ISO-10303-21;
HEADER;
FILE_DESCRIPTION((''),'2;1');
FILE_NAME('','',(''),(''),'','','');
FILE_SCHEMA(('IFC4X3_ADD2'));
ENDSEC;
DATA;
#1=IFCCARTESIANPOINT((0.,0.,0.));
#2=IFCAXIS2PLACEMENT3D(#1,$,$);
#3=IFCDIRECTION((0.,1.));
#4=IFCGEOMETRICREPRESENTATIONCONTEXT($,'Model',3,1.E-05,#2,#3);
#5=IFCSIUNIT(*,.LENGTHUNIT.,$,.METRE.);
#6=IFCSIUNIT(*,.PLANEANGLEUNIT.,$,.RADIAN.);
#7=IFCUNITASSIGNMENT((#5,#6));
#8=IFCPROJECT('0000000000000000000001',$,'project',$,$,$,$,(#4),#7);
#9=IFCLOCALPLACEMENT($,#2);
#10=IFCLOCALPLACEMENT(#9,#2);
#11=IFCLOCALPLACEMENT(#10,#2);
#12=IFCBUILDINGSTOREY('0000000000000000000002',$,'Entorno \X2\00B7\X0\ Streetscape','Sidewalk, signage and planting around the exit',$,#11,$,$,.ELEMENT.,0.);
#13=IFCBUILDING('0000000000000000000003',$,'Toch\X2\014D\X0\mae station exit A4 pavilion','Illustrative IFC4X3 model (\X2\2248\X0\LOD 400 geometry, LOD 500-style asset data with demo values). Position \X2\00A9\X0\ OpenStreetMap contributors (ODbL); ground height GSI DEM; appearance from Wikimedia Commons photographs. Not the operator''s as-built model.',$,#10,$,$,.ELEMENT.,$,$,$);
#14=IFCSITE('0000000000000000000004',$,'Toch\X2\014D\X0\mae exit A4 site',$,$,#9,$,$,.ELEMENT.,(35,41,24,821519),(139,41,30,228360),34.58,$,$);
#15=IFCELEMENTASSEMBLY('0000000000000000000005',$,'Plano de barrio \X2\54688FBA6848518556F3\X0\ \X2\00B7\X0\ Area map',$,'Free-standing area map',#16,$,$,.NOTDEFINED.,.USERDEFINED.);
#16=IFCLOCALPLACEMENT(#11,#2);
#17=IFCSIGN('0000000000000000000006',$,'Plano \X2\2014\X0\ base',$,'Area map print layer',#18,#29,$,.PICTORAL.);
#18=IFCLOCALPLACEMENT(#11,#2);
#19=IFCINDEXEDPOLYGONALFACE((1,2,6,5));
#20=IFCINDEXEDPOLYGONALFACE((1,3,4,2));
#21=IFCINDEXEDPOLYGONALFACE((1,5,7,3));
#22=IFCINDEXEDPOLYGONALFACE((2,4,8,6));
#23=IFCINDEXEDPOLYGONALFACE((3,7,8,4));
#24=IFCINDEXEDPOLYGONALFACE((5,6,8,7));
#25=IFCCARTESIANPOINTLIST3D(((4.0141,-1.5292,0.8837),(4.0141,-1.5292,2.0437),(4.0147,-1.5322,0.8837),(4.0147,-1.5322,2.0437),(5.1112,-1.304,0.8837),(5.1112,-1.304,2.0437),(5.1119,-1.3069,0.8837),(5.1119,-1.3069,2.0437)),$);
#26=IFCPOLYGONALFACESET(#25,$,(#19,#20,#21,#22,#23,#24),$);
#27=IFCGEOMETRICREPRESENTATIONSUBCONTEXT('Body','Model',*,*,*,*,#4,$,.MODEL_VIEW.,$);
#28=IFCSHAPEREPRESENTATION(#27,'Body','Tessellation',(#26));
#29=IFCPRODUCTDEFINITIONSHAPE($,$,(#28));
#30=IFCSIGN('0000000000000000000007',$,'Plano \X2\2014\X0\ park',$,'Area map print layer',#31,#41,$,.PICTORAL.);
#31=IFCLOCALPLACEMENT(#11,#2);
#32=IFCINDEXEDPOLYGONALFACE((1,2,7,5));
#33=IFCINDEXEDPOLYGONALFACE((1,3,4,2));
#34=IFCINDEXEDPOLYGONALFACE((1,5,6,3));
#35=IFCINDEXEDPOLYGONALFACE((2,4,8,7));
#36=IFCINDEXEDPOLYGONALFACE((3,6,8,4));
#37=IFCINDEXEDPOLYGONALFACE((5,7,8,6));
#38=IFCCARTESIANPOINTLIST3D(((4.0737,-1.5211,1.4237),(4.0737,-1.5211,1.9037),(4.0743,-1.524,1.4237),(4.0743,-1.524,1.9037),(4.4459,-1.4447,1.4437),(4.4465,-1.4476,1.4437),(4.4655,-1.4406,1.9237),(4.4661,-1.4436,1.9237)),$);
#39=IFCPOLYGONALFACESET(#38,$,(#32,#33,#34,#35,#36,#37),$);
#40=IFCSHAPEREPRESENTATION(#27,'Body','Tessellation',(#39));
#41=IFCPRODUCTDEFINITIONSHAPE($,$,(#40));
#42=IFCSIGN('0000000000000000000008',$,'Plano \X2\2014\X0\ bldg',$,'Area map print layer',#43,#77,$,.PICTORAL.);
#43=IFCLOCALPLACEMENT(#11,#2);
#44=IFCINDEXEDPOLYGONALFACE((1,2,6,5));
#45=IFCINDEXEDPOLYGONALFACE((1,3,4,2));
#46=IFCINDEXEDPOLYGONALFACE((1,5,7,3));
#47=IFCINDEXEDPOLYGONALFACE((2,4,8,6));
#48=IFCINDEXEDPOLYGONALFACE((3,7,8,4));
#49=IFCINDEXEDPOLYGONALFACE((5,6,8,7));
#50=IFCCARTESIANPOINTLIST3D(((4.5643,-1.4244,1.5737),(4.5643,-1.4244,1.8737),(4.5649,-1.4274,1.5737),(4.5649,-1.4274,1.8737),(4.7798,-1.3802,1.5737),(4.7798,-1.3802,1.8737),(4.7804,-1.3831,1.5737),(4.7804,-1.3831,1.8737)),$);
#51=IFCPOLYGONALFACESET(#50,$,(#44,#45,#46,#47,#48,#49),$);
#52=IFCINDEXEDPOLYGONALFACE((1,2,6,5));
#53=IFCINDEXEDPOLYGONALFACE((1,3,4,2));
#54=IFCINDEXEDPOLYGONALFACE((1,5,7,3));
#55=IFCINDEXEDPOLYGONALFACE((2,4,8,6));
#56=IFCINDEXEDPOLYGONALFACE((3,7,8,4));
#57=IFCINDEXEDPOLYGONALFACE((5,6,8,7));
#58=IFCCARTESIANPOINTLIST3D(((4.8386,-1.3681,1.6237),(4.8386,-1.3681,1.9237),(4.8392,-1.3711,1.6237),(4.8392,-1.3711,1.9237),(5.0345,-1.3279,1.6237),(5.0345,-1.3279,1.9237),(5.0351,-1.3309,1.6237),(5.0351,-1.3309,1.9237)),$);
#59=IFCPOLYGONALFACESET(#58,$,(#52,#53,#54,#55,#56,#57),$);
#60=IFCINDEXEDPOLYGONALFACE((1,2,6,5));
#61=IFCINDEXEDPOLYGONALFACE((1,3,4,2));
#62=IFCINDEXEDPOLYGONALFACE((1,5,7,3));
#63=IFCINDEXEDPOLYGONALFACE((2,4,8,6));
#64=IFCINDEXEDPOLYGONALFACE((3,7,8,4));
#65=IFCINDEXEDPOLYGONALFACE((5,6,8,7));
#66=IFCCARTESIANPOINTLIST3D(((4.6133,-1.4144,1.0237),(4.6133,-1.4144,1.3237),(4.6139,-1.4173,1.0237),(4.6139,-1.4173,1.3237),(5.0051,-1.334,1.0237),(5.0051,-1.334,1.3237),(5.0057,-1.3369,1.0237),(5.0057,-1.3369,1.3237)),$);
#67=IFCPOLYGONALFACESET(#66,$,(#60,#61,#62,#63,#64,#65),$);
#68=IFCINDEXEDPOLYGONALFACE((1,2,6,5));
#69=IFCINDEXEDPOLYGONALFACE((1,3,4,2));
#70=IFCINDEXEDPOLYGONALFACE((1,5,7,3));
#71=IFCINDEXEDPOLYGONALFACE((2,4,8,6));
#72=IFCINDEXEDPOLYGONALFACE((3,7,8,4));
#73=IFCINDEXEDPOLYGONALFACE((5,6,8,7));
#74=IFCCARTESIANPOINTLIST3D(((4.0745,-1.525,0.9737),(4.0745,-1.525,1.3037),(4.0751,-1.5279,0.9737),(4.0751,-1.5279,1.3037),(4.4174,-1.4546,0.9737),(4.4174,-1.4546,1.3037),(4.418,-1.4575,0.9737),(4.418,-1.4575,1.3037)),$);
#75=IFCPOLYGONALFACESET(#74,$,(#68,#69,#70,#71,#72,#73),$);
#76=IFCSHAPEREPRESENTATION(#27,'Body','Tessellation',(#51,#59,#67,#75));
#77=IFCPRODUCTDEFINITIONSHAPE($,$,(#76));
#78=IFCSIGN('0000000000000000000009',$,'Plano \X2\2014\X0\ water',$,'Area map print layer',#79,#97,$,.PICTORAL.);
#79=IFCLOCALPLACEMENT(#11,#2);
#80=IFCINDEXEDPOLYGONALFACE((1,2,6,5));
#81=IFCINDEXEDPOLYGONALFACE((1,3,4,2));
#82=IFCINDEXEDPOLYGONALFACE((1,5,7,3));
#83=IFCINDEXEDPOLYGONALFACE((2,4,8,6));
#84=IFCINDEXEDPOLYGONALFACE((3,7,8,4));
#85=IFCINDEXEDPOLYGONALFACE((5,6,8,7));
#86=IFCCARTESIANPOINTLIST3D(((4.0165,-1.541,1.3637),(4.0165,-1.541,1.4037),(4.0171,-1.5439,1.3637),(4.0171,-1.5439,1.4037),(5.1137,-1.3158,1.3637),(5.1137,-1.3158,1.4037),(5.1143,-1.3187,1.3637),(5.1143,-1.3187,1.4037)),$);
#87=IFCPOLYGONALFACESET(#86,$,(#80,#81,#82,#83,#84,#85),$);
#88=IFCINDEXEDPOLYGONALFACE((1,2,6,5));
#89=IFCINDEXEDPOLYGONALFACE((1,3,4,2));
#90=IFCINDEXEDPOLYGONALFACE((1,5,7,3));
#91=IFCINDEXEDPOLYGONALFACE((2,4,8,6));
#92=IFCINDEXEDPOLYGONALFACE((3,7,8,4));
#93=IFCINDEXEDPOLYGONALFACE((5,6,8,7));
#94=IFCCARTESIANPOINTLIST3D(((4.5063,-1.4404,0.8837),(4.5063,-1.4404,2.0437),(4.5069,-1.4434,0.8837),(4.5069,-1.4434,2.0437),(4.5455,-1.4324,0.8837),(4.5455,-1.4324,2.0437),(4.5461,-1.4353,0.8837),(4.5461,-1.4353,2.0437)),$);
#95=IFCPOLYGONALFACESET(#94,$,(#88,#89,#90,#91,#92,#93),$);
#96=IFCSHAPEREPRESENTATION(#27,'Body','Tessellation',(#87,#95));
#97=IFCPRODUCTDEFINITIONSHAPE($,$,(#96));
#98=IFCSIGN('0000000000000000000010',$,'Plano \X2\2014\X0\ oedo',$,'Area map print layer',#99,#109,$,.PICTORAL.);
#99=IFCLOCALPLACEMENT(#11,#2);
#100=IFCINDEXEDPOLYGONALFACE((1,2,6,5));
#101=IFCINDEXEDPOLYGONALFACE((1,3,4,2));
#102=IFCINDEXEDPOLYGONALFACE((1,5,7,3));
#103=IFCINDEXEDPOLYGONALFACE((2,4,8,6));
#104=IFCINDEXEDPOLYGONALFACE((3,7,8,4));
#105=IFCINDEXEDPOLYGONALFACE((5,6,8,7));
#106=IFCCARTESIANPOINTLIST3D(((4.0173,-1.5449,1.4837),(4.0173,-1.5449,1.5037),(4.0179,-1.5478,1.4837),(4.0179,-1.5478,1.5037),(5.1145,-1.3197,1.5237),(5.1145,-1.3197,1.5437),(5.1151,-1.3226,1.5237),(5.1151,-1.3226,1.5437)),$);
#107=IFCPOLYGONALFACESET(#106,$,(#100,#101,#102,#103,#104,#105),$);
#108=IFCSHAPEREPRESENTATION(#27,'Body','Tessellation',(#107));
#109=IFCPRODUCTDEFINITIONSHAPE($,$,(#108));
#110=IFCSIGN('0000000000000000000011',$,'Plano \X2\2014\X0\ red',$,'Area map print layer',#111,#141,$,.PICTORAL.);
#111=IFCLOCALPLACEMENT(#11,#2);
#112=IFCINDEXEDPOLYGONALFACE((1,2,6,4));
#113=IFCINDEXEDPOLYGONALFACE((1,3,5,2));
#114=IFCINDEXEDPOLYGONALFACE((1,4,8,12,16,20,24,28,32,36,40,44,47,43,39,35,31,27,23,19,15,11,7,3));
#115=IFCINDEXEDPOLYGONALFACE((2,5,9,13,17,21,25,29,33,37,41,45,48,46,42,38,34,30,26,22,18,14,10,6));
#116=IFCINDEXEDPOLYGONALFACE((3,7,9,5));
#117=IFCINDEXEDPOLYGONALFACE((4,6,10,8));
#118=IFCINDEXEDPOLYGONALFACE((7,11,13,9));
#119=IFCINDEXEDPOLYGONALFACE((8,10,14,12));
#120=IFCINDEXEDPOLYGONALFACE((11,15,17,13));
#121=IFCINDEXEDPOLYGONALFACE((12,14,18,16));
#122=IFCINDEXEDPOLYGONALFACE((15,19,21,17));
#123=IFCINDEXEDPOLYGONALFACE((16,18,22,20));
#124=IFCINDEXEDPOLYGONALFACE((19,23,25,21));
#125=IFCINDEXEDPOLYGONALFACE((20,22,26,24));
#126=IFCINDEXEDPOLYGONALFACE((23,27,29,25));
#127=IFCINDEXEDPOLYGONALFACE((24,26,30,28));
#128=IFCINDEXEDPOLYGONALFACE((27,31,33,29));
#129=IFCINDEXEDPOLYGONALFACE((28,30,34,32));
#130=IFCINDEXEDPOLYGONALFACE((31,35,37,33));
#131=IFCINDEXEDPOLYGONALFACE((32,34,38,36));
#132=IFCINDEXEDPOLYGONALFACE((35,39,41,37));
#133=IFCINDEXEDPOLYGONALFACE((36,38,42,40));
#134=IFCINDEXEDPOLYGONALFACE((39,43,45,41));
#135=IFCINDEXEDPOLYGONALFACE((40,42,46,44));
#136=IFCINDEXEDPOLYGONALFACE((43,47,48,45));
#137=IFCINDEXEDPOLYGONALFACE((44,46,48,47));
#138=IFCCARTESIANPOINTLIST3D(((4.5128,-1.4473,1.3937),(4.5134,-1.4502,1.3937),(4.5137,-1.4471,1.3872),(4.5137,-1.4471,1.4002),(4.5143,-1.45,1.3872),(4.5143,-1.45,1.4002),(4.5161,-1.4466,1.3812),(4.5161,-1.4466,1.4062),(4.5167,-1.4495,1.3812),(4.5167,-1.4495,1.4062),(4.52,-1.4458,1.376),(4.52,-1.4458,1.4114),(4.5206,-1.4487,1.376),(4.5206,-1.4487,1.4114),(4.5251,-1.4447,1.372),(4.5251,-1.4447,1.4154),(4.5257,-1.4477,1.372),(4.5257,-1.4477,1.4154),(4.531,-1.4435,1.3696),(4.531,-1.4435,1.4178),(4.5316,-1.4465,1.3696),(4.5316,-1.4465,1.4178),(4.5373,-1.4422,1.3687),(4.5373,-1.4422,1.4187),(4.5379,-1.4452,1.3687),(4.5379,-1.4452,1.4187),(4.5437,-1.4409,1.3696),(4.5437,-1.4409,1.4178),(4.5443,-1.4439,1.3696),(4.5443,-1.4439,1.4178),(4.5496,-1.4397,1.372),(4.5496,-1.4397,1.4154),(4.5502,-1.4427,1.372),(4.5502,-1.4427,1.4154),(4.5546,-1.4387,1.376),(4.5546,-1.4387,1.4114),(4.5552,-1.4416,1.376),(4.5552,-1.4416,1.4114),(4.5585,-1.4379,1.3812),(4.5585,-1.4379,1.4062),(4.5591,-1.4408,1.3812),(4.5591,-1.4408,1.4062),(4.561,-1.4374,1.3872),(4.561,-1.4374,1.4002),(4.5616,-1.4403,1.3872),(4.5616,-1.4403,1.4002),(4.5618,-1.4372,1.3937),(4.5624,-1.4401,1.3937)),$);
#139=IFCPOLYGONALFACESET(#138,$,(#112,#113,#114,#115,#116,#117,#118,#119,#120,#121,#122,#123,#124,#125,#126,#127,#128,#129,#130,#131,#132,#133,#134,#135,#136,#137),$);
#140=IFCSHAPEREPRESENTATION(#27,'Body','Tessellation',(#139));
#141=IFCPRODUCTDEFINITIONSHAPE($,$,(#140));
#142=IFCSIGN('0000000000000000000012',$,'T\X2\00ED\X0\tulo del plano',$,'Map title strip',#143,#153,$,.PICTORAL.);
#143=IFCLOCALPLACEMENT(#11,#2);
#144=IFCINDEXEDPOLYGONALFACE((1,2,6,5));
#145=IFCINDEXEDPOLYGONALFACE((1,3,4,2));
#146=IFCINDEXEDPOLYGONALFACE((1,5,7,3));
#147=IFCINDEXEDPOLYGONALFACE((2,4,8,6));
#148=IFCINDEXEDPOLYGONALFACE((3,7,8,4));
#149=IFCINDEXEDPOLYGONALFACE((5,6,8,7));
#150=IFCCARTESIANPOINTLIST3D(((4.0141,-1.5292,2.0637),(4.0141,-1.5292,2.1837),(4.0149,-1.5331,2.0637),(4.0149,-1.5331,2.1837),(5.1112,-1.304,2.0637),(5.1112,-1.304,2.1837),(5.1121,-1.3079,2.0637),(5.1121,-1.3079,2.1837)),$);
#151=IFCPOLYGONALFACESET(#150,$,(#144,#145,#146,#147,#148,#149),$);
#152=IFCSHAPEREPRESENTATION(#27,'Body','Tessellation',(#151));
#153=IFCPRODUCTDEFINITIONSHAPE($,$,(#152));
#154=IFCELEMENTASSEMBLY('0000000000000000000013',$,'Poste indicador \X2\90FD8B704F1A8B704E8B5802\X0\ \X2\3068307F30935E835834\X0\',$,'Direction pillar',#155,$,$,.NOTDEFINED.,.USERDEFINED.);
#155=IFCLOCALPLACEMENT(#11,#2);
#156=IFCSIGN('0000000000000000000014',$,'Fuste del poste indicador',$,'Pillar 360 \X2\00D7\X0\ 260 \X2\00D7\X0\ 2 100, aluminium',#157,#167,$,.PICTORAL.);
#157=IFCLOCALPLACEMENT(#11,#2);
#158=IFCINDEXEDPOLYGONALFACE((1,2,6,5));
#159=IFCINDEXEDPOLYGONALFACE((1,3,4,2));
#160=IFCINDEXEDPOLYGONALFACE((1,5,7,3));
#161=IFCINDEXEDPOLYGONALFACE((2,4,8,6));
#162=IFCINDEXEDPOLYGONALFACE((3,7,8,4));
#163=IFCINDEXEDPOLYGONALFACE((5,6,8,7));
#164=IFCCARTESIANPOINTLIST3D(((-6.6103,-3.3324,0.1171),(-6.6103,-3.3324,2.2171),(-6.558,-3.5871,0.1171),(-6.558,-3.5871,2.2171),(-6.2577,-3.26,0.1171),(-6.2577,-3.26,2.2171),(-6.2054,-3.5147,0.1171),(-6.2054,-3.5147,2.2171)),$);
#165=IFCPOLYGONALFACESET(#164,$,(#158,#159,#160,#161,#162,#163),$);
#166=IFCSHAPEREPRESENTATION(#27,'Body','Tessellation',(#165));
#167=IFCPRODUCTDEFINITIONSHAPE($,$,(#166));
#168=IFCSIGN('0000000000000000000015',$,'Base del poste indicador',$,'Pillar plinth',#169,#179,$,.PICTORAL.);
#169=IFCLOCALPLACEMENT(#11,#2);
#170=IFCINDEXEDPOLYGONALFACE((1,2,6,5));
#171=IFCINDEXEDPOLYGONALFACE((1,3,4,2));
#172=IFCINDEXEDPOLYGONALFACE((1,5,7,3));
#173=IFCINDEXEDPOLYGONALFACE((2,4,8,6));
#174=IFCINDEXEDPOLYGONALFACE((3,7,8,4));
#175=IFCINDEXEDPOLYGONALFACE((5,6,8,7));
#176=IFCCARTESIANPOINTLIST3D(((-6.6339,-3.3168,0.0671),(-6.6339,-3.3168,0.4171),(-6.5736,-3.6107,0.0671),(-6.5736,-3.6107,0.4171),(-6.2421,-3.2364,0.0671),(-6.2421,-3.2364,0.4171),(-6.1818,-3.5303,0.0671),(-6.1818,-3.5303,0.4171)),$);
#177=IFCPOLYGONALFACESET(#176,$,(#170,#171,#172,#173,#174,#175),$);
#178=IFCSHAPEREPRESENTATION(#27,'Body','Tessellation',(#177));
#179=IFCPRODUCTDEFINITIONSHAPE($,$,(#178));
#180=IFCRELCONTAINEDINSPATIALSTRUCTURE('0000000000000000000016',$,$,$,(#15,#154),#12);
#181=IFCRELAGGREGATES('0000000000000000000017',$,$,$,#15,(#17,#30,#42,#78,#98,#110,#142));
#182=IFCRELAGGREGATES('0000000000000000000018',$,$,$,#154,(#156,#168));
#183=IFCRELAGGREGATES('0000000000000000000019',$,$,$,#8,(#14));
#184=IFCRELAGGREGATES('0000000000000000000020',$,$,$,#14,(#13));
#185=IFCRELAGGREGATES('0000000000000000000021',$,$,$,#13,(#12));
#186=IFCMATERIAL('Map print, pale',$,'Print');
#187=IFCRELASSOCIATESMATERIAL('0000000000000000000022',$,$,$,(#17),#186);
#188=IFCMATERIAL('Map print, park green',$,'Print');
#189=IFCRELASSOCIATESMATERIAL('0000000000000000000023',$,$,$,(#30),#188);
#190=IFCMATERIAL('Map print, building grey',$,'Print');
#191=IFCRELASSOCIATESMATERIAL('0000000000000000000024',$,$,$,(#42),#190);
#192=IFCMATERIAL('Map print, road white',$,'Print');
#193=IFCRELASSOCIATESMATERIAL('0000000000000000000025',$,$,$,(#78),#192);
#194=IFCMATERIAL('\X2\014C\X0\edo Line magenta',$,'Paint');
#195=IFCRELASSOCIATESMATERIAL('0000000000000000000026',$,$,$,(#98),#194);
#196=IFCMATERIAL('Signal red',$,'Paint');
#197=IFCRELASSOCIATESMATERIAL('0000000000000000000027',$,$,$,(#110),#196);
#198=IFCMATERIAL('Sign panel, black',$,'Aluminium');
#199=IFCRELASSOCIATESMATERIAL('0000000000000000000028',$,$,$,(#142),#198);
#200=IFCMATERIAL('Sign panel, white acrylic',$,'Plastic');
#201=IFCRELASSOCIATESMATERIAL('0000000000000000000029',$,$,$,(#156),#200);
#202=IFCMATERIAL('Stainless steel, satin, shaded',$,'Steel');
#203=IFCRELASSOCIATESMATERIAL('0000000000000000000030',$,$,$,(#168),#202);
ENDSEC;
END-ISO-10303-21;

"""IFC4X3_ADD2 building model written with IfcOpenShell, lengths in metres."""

from ifc_helpers import new_model, si_unit, direction, frame, frame_2d, origin, place, context, subcontext, project, spatial, polyline, rectangle, outline, extrude, material, element, aggregate, save


model = new_model("IFC4X3_ADD2")

# Units and contexts
model_context = context("Model", 3, precision=1e-05, world=origin(), true_north=direction((0.0, 1.0)))
body_context = subcontext(model_context, "Body", "Model", "MODEL_VIEW")
ifc_project = project(units=[si_unit("LENGTHUNIT", "METRE"), si_unit("PLANEANGLEUNIT", "RADIAN")], contexts=[model_context])

# Site, building, storey
site_placement = place(None, origin())
site = spatial("IfcSite", under=ifc_project, at=site_placement, Name="Tochōmae exit A4 site", CompositionType="ELEMENT", RefLatitude=(35, 41, 24, 821519), RefLongitude=(139, 41, 30, 228360), RefElevation=34.58)
building_placement = place(site_placement, origin())
building = spatial("IfcBuilding", under=site, at=building_placement, Name="Tochōmae station exit A4 pavilion", Description="Illustrative IFC4X3 model (≈LOD 400 geometry, LOD 500-style asset data with demo values). Position © OpenStreetMap contributors (ODbL); ground height GSI DEM; appearance from Wikimedia Commons photographs. Not the operator's as-built model.", CompositionType="ELEMENT")
storey_placement = place(building_placement, origin())
storey = spatial("IfcBuildingStorey", under=building, at=storey_placement, Name="Entorno · Streetscape", Description="Sidewalk, signage and planting around the exit", CompositionType="ELEMENT", Elevation=0.0)

# Element assembly
assembly_1_placement = place(building_placement, origin())
assembly_1 = element("IfcElementAssembly", 1, at=assembly_1_placement, inside=storey, Name="Plano de barrio 周辺案内図 · Area map", ObjectType="Free-standing area map", AssemblyPlace="NOTDEFINED", PredefinedType="USERDEFINED")
ifc_material_1 = material(Name="Stainless steel, satin, shaded", Category="Steel")

# Signs
ifc_material_2 = material(Name="Map print, pale", Category="Print")
sign_1_placement = place(building_placement, origin())
sign_1 = element("IfcSign", 2, at=sign_1_placement, material=ifc_material_2, Name="Plano — base", ObjectType="Area map print layer", PredefinedType="PICTORAL", context=body_context, shape_type="SweptSolid", body=[
    extrude(outline(polyline([(-0.56, 0.8837), (0.56, 0.8837), (0.56, 2.0437), (-0.56, 2.0437), (-0.56, 0.8837)])), frame((4.5627, -1.4166, 0.0), z_axis=(0.201078, -0.979575, 0.0), x_axis=(0.979575, 0.201078, 0.0)), (0.0, 0.0, 1.0), 0.003),
])
ifc_material_3 = material(Name="Map print, park green", Category="Print")
sign_2_placement = place(building_placement, origin())
sign_2 = element("IfcSign", 3, at=sign_2_placement, material=ifc_material_3, Name="Plano — park", ObjectType="Area map print layer", PredefinedType="PICTORAL", context=body_context, shape_type="SweptSolid", body=[
    extrude(outline(polyline([(-0.5, 1.4237), (-0.12, 1.4437), (-0.1, 1.9237), (-0.5, 1.9037), (-0.5, 1.4237)])), frame((4.5635, -1.4205, 0.0), z_axis=(0.201078, -0.979575, 0.0), x_axis=(0.979575, 0.201078, 0.0)), (0.0, 0.0, 1.0), 0.003),
])
ifc_material_4 = material(Name="Map print, building grey", Category="Print")
sign_3_placement = place(building_placement, origin())
sign_3 = element("IfcSign", 4, at=sign_3_placement, material=ifc_material_4, Name="Plano — bldg", ObjectType="Area map print layer", PredefinedType="PICTORAL", context=body_context, shape_type="SweptSolid", body=[
    extrude(outline(polyline([(0.0, 1.5737), (0.22, 1.5737), (0.22, 1.8737), (0.0, 1.8737), (0.0, 1.5737)])), frame((4.5643, -1.4244, 0.0), z_axis=(0.201078, -0.979575, 0.0), x_axis=(0.979575, 0.201078, 0.0)), (0.0, 0.0, 1.0), 0.003),
    extrude(outline(polyline([(0.28, 1.6237), (0.48, 1.6237), (0.48, 1.9237), (0.28, 1.9237), (0.28, 1.6237)])), frame((4.5643, -1.4244, 0.0), z_axis=(0.201078, -0.979575, 0.0), x_axis=(0.979575, 0.201078, 0.0)), (0.0, 0.0, 1.0), 0.003),
    extrude(outline(polyline([(0.05, 1.0237), (0.45, 1.0237), (0.45, 1.3237), (0.05, 1.3237), (0.05, 1.0237)])), frame((4.5643, -1.4244, 0.0), z_axis=(0.201078, -0.979575, 0.0), x_axis=(0.979575, 0.201078, 0.0)), (0.0, 0.0, 1.0), 0.003),
    extrude(outline(polyline([(-0.5, 0.9737), (-0.15, 0.9737), (-0.15, 1.3037), (-0.5, 1.3037), (-0.5, 0.9737)])), frame((4.5643, -1.4244, 0.0), z_axis=(0.201078, -0.979575, 0.0), x_axis=(0.979575, 0.201078, 0.0)), (0.0, 0.0, 1.0), 0.003),
])
ifc_material_5 = material(Name="Map print, road white", Category="Print")
sign_4_placement = place(building_placement, origin())
sign_4 = element("IfcSign", 5, at=sign_4_placement, material=ifc_material_5, Name="Plano — water", ObjectType="Area map print layer", PredefinedType="PICTORAL", context=body_context, shape_type="SweptSolid", body=[
    extrude(outline(polyline([(-0.56, 1.3637), (0.56, 1.3637), (0.56, 1.4037), (-0.56, 1.4037), (-0.56, 1.3637)])), frame((4.5651, -1.4284, 0.0), z_axis=(0.201078, -0.979575, 0.0), x_axis=(0.979575, 0.201078, 0.0)), (0.0, 0.0, 1.0), 0.003),
    extrude(outline(polyline([(-0.06, 0.8837), (-0.02, 0.8837), (-0.02, 2.0437), (-0.06, 2.0437), (-0.06, 0.8837)])), frame((4.5651, -1.4284, 0.0), z_axis=(0.201078, -0.979575, 0.0), x_axis=(0.979575, 0.201078, 0.0)), (0.0, 0.0, 1.0), 0.003),
])
ifc_material_6 = material(Name="Ōedo Line magenta", Category="Paint")
sign_5_placement = place(building_placement, origin())
sign_5 = element("IfcSign", 6, at=sign_5_placement, material=ifc_material_6, Name="Plano — oedo", ObjectType="Area map print layer", PredefinedType="PICTORAL", context=body_context, shape_type="SweptSolid", body=[
    extrude(outline(polyline([(-0.56, 1.4837), (0.56, 1.5237), (0.56, 1.5437), (-0.56, 1.5037), (-0.56, 1.4837)])), frame((4.5659, -1.4323, 0.0), z_axis=(0.201078, -0.979575, 0.0), x_axis=(0.979575, 0.201078, 0.0)), (0.0, 0.0, 1.0), 0.003),
])
ifc_material_7 = material(Name="Signal red", Category="Paint")
sign_6_placement = place(building_placement, origin())
sign_6 = element("IfcSign", 7, at=sign_6_placement, material=ifc_material_7, Name="Plano — red", ObjectType="Area map print layer", PredefinedType="PICTORAL", context=body_context, shape_type="SweptSolid", body=[
    extrude(outline(polyline([(-0.005, 1.3937), (-0.0059, 1.3872), (-0.0083, 1.3812), (-0.0123, 1.376), (-0.0175, 1.372), (-0.0235, 1.3696), (-0.03, 1.3687), (-0.0365, 1.3696), (-0.0425, 1.372), (-0.0477, 1.376), (-0.0517, 1.3812), (-0.0541, 1.3872), (-0.055, 1.3937), (-0.0541, 1.4002), (-0.0517, 1.4062), (-0.0477, 1.4114), (-0.0425, 1.4154), (-0.0365, 1.4178), (-0.03, 1.4187), (-0.0235, 1.4178), (-0.0175, 1.4154), (-0.0123, 1.4114), (-0.0083, 1.4062), (-0.0059, 1.4002), (-0.005, 1.3937)])), frame((4.5667, -1.4362, 0.0), z_axis=(0.201078, -0.979575, 0.0), x_axis=(0.979575, 0.201078, 0.0)), (0.0, 0.0, 1.0), 0.003),
])
ifc_material_8 = material(Name="Sign panel, black", Category="Aluminium")
sign_7_placement = place(building_placement, origin())
sign_7 = element("IfcSign", 8, at=sign_7_placement, material=ifc_material_8, Name="Título del plano", ObjectType="Map title strip", PredefinedType="PICTORAL", context=body_context, shape_type="SweptSolid", body=[
    extrude(outline(polyline([(-0.56, 2.0637), (0.56, 2.0637), (0.56, 2.1837), (-0.56, 2.1837), (-0.56, 2.0637)])), frame((4.5627, -1.4166, 0.0), z_axis=(0.201078, -0.979575, 0.0), x_axis=(0.979575, 0.201078, 0.0)), (0.0, 0.0, 1.0), 0.004),
])
ifc_material_9 = material(Name="Sign panel, white acrylic", Category="Plastic")
aggregate(assembly_1, [sign_1, sign_2, sign_3, sign_4, sign_5, sign_6, sign_7])

# Element assembly, signs
assembly_2_placement = place(building_placement, origin())
assembly_2 = element("IfcElementAssembly", 9, at=assembly_2_placement, inside=storey, Name="Poste indicador 都議会議事堂 とみん広場", ObjectType="Direction pillar", AssemblyPlace="NOTDEFINED", PredefinedType="USERDEFINED")
sign_8_placement = place(building_placement, origin())
sign_8 = element("IfcSign", 10, at=sign_8_placement, material=ifc_material_9, Name="Fuste del poste indicador", ObjectType="Pillar 360 × 260 × 2 100, aluminium", PredefinedType="PICTORAL", context=body_context, shape_type="SweptSolid", body=[
    extrude(rectangle(XDim=0.36, YDim=0.26, at=frame_2d((0.0, 0.0), x_axis=(0.979575, 0.201078))), frame((-6.4078, -3.4235, 0.1171)), (0.0, 0.0, 1.0), 2.1),
])
sign_9_placement = place(building_placement, origin())
sign_9 = element("IfcSign", 11, at=sign_9_placement, material=ifc_material_1, Name="Base del poste indicador", ObjectType="Pillar plinth", PredefinedType="PICTORAL", context=body_context, shape_type="SweptSolid", body=[
    extrude(rectangle(XDim=0.4, YDim=0.3, at=frame_2d((0.0, 0.0), x_axis=(0.979575, 0.201078))), frame((-6.4078, -3.4235, 0.0671)), (0.0, 0.0, 1.0), 0.35),
])
aggregate(assembly_2, [sign_8, sign_9])

save(model, "model.ifc")
